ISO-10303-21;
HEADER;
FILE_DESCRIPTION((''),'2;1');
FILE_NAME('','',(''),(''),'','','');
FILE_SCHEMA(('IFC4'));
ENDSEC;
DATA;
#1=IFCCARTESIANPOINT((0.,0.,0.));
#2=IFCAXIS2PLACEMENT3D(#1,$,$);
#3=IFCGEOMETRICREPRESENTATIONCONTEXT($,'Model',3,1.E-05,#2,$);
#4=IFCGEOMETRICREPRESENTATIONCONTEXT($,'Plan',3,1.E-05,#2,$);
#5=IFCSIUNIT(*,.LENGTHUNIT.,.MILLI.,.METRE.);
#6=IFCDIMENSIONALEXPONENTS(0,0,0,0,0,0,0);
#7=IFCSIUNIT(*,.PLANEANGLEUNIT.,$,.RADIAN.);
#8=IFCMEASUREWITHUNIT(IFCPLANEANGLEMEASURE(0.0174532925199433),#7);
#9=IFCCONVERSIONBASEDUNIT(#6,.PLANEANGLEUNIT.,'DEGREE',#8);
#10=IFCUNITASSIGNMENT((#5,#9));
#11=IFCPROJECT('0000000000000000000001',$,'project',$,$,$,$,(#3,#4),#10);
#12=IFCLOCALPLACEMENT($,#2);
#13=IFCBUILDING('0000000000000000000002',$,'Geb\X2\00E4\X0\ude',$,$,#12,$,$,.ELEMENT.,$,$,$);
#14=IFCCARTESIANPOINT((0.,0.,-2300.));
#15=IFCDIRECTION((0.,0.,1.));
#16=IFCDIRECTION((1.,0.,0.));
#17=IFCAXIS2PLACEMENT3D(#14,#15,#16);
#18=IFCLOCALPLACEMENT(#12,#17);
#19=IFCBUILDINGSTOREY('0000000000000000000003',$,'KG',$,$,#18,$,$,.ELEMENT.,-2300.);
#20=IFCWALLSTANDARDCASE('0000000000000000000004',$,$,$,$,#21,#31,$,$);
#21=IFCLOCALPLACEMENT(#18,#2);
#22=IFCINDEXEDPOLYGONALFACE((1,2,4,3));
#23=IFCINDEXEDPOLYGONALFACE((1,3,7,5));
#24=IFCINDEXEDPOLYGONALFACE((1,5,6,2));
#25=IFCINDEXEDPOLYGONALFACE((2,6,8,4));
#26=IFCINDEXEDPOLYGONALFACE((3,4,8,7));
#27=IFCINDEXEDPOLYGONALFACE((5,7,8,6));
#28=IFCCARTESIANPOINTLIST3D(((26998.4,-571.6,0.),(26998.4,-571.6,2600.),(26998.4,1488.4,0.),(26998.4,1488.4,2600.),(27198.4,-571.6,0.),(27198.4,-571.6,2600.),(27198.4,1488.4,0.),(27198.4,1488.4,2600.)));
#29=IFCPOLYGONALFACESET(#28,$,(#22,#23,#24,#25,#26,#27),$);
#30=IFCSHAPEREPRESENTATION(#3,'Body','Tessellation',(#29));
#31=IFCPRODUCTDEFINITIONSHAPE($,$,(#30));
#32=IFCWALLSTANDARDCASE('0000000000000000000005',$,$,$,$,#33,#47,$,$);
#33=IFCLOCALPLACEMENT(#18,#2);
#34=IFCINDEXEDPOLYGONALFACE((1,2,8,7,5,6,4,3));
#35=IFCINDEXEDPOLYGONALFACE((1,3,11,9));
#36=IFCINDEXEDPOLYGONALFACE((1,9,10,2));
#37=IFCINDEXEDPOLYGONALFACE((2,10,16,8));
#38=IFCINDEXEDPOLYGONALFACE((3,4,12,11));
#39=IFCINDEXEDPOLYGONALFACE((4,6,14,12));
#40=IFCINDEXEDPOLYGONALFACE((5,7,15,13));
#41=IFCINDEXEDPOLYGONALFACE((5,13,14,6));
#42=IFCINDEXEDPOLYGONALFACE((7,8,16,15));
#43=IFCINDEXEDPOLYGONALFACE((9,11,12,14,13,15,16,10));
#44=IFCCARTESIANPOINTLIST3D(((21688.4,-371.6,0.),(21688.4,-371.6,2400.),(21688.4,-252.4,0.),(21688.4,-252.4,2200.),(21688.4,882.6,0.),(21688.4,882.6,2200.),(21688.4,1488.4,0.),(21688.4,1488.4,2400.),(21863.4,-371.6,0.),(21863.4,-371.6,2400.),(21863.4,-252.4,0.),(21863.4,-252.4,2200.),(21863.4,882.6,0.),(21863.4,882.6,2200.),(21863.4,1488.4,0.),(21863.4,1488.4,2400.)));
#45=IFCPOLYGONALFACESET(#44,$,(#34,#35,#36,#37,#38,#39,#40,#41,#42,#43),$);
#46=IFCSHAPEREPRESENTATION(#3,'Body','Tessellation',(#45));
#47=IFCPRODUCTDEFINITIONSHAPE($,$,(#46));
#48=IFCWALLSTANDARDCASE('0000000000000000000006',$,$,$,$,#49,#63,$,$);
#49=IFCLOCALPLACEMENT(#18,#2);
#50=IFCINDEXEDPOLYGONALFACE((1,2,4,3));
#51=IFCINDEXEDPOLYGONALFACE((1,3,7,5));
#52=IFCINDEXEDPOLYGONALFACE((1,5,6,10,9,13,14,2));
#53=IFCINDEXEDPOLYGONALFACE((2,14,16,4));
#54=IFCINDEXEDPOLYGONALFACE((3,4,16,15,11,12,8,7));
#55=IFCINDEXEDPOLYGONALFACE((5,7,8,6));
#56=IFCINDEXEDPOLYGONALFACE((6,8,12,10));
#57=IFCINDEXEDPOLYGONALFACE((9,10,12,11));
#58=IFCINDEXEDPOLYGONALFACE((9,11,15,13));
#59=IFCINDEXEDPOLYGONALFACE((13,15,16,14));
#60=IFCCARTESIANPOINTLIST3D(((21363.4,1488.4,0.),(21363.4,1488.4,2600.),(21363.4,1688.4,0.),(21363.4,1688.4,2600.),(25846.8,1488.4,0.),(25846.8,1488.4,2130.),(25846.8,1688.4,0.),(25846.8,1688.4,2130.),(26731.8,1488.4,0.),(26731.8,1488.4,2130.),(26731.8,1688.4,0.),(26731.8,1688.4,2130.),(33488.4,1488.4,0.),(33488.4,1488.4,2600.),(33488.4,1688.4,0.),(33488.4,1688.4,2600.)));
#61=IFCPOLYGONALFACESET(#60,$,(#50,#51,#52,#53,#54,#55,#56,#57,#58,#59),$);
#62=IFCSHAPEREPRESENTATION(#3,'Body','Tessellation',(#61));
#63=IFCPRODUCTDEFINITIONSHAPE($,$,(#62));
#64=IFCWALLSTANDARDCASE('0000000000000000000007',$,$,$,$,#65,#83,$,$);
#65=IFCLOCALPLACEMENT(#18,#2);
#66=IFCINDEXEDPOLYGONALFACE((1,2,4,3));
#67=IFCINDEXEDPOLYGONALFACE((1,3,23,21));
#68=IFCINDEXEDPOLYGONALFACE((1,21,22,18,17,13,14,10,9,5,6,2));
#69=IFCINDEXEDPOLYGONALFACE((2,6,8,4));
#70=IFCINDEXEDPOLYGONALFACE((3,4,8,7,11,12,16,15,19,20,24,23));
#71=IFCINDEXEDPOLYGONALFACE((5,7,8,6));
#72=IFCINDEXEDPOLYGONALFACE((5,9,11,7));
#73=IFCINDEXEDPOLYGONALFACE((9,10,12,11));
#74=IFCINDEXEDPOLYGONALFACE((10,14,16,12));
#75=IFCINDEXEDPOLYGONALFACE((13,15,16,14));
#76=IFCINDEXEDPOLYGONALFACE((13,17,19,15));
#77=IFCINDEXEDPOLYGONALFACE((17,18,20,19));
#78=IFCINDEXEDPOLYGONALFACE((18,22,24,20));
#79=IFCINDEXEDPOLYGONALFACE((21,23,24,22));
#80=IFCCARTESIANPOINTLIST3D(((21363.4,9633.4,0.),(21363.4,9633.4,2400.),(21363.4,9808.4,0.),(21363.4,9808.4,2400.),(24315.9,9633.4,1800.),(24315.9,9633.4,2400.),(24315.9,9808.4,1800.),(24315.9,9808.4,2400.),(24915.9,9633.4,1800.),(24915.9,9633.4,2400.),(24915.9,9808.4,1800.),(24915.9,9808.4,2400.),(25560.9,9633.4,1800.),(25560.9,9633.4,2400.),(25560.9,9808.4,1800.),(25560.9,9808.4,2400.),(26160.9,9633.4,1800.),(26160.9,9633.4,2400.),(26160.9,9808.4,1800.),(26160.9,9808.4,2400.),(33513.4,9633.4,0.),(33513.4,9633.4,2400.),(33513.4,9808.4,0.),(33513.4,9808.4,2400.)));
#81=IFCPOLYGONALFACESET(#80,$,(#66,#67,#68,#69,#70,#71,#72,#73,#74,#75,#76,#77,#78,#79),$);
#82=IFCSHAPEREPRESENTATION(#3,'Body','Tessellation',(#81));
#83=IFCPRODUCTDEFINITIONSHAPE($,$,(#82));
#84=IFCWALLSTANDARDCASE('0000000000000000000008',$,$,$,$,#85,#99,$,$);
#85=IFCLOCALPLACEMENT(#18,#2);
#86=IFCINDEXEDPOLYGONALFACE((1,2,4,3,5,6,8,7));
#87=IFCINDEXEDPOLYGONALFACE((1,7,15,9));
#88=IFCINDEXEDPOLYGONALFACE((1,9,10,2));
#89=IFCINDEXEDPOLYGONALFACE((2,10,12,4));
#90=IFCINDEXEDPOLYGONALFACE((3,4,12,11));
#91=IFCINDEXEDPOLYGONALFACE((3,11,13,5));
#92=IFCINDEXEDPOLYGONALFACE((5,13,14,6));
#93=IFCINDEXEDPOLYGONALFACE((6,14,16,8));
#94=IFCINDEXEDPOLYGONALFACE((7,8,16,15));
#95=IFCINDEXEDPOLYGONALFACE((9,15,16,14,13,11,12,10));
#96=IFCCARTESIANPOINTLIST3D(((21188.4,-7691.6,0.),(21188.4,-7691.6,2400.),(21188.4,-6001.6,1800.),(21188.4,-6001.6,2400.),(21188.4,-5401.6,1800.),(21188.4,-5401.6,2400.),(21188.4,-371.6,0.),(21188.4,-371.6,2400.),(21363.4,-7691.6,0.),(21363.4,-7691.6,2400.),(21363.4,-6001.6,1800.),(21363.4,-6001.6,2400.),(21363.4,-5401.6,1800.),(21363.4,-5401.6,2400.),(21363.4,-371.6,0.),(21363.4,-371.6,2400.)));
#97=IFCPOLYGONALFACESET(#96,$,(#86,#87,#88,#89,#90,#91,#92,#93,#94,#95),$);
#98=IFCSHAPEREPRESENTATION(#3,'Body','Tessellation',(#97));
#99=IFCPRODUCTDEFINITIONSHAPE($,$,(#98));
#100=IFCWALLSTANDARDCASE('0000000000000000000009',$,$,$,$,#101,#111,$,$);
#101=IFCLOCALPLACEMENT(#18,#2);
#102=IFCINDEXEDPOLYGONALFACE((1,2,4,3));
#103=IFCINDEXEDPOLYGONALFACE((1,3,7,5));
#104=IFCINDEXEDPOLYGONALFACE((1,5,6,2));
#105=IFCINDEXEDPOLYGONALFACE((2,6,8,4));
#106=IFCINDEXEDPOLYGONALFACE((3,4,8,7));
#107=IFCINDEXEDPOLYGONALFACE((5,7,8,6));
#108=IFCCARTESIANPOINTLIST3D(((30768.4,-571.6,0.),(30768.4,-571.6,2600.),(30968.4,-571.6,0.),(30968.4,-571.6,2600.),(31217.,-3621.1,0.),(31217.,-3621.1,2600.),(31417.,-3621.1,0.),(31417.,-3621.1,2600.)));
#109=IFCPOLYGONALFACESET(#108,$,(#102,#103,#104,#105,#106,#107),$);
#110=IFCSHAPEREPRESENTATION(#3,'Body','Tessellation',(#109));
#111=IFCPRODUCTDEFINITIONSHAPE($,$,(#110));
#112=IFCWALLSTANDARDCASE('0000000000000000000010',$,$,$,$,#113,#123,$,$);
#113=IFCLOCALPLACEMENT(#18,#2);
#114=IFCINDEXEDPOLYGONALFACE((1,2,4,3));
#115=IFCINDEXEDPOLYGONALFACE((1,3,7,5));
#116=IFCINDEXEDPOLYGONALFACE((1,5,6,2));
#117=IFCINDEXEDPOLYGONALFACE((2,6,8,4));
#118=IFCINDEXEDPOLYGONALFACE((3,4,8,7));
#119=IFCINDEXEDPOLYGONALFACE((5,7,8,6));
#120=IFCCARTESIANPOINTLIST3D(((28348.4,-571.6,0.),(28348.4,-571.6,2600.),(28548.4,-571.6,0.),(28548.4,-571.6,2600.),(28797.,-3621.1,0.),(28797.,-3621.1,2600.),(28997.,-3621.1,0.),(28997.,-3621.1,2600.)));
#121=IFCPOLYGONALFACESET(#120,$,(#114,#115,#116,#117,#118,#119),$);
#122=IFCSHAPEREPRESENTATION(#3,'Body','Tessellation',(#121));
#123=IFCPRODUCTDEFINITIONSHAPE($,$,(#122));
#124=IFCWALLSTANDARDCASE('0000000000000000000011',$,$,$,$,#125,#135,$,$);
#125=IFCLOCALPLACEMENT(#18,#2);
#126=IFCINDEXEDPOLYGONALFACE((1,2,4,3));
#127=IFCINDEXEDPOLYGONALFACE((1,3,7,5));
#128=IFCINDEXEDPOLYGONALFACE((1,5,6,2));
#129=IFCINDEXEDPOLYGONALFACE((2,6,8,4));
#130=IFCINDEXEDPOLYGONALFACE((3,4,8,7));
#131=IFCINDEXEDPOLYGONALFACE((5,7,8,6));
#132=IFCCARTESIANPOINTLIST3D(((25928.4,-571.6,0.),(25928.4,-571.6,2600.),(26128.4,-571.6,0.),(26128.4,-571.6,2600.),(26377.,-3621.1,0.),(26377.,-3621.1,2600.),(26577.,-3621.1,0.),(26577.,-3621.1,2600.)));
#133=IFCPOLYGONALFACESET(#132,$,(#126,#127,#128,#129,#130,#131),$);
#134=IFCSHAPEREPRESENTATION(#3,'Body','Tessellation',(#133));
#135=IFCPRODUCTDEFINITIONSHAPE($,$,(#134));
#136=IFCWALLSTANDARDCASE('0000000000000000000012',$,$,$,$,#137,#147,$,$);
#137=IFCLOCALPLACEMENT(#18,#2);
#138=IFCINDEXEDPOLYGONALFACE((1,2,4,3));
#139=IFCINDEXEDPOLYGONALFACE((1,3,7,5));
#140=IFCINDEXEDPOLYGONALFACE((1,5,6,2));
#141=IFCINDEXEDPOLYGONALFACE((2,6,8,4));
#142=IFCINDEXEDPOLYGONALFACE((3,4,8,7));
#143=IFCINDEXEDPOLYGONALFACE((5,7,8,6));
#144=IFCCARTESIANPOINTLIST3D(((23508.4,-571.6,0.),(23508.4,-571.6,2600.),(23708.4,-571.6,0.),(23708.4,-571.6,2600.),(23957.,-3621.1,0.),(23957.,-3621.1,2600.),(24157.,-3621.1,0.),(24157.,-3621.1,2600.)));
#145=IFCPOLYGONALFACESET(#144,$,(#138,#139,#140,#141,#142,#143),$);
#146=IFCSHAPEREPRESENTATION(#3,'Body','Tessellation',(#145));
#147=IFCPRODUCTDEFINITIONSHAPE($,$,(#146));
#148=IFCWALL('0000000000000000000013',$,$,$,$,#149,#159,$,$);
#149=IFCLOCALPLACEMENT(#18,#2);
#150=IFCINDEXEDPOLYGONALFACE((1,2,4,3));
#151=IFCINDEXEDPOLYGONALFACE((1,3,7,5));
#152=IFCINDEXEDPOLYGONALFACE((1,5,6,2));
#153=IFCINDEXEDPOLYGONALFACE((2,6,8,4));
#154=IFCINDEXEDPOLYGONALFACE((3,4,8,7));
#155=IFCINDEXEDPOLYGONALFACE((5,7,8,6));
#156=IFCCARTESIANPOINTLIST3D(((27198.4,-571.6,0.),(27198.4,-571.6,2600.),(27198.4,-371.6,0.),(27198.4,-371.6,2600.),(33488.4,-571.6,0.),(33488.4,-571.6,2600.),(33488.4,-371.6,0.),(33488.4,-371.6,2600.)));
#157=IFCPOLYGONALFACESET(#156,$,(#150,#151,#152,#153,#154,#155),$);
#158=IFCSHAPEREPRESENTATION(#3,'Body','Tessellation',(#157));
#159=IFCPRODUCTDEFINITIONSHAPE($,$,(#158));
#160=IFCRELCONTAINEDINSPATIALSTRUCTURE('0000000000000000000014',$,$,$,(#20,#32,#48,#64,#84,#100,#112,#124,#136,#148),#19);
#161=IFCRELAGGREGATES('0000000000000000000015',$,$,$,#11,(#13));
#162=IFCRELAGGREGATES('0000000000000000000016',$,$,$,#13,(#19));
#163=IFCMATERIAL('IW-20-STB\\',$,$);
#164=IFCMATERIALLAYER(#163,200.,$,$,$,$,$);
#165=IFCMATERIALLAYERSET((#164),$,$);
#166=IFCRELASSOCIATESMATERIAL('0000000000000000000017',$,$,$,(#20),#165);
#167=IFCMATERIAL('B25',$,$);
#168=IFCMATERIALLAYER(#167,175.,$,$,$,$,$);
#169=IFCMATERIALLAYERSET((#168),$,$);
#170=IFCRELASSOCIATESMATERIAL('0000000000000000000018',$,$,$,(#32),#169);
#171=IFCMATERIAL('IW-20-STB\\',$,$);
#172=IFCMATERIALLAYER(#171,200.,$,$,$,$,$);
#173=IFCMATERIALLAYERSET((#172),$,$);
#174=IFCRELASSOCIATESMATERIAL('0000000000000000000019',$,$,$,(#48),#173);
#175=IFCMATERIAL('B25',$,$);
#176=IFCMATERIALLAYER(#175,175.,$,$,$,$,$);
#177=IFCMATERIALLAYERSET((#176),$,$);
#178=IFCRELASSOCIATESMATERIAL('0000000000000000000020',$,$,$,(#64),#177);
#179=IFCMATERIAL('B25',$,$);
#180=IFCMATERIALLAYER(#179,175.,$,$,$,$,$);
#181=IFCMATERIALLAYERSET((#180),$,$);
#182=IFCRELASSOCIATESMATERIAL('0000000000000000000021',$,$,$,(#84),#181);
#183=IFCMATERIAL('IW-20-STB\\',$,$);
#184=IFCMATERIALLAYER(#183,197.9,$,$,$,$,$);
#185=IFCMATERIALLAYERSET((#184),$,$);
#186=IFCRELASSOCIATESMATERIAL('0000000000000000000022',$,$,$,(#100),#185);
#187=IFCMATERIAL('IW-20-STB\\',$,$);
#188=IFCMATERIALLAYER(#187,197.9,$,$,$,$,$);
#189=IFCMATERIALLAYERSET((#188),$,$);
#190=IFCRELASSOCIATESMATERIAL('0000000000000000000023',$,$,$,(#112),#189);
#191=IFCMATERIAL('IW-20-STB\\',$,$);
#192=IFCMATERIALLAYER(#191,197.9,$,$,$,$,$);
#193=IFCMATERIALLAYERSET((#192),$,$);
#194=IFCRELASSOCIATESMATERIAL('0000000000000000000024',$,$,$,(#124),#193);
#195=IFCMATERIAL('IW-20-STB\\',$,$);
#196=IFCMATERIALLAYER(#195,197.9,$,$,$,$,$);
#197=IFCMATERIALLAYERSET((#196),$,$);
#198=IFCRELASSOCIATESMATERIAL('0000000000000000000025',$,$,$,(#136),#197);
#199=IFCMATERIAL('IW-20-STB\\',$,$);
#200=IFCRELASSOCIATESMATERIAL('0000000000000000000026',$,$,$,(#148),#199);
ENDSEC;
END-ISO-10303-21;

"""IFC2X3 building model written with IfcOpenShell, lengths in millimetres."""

from ifc_helpers import new_model, entity, si_unit, converted_unit, frame, frame_2d, origin, origin_with_axes, place, context, project, spatial, polyline, rectangle, outline, extrude, material, layer, layer_set, layer_usage, element, save


model = new_model("IFC2X3")

# Units and contexts
model_context = context("Model", 3, precision=1e-05, world=origin())
plan_context = context("Plan", 3, precision=1e-05, world=origin())
ifc_project = project(units=[si_unit("LENGTHUNIT", "METRE", prefix="MILLI"), converted_unit("PLANEANGLEUNIT", "DEGREE", entity("IfcPlaneAngleMeasure", 0.0174532925199433), si_unit("PLANEANGLEUNIT", "RADIAN"), dimensions=[0, 0, 0, 0, 0, 0, 0])], contexts=[model_context, plan_context])

# Building, storey
building_placement = place(None, origin())
building = spatial("IfcBuilding", under=ifc_project, at=building_placement, Name="Gebäude", CompositionType="ELEMENT")
storey_placement = place(building_placement, frame((0.0, 0.0, -2300.0), z_axis=(0.0, 0.0, 1.0), x_axis=(1.0, 0.0, 0.0)))
storey = spatial("IfcBuildingStorey", under=building, at=storey_placement, Name="KG", CompositionType="ELEMENT", Elevation=-2300.0)

# Wall
ifc_material_1 = material(Name="IW-20-STB\\")
ifc_layer_1 = layer(ifc_material_1, 200.0)
ifc_layer_set_1 = layer_set([ifc_layer_1])
ifc_layer_usage_1 = layer_usage(ifc_layer_set_1, "AXIS2", "POSITIVE", -200.0)
wall_1_placement = place(storey_placement, frame((26998.4, 1488.4, 0.0), z_axis=(0.0, 0.0, 1.0), x_axis=(0.0, -1.0, 0.0)))
element("IfcWallStandardCase", 1, at=wall_1_placement, inside=storey, material=ifc_layer_usage_1, context=model_context, shape_type="SweptSolid", body=[
    extrude(rectangle(XDim=2060.0, YDim=200.0, at=frame_2d((1030.0, 100.0), x_axis=(1.0, 0.0))), origin_with_axes(), (0.0, 0.0, 1.0), 2600.0),
])

# Walls, openings
ifc_material_2 = material(Name="B25")
ifc_layer_2 = layer(ifc_material_2, 175.0)
ifc_layer_set_2 = layer_set([ifc_layer_2])
ifc_layer_usage_2 = layer_usage(ifc_layer_set_2, "AXIS2", "POSITIVE", 0.0)
wall_2_placement = place(storey_placement, frame((21688.4, 1488.4, 0.0), z_axis=(0.0, 0.0, 1.0), x_axis=(0.0, -1.0, 0.0)))
wall_2 = element("IfcWallStandardCase", 2, at=wall_2_placement, inside=storey, material=ifc_layer_usage_2, context=model_context, shape_type="SweptSolid", body=[
    extrude(rectangle(XDim=1860.0, YDim=175.0, at=frame_2d((930.0, 87.5), x_axis=(1.0, 0.0))), origin_with_axes(), (0.0, 0.0, 1.0), 2400.0),
])
opening_1_placement = place(wall_2_placement, frame((605.8, 0.0, 0.0), z_axis=(0.0, 1.0, 0.0), x_axis=(0.0, 0.0, 1.0)))
element("IfcOpeningElement", 3, at=opening_1_placement, cuts=wall_2, ObjectType="Opening", context=model_context, shape_type="SweptSolid", body=[
    extrude(rectangle(XDim=2200.0, YDim=1135.0, at=frame_2d((1100.0, 567.5), x_axis=(1.0, 0.0))), origin_with_axes(), (0.0, 0.0, 1.0), 175.0),
])
ifc_material_3 = material(Name="IW-20-STB\\")
ifc_layer_3 = layer(ifc_material_3, 200.0)
ifc_layer_set_3 = layer_set([ifc_layer_3])
ifc_layer_usage_3 = layer_usage(ifc_layer_set_3, "AXIS2", "POSITIVE", -200.0)
wall_3_placement = place(storey_placement, frame((21363.4, 1488.4, 0.0), z_axis=(0.0, 0.0, 1.0), x_axis=(1.0, 0.0, 0.0)))
wall_3 = element("IfcWallStandardCase", 4, at=wall_3_placement, inside=storey, material=ifc_layer_usage_3, context=model_context, shape_type="SweptSolid", body=[
    extrude(rectangle(XDim=12125.0, YDim=200.0, at=frame_2d((6062.5, 100.0), x_axis=(1.0, 0.0))), origin_with_axes(), (0.0, 0.0, 1.0), 2600.0),
])
opening_2_placement = place(wall_3_placement, frame((4483.5, 0.0, 0.0), z_axis=(0.0, 1.0, 0.0), x_axis=(0.0, 0.0, 1.0)))
element("IfcOpeningElement", 5, at=opening_2_placement, cuts=wall_3, ObjectType="Opening", context=model_context, shape_type="SweptSolid", body=[
    extrude(rectangle(XDim=2130.0, YDim=885.0, at=frame_2d((1065.0, 442.5), x_axis=(1.0, 0.0))), origin_with_axes(), (0.0, 0.0, 1.0), 200.0),
])

# Wall, openings
ifc_material_4 = material(Name="B25")
ifc_layer_4 = layer(ifc_material_4, 175.0)
ifc_layer_set_4 = layer_set([ifc_layer_4])
ifc_layer_usage_4 = layer_usage(ifc_layer_set_4, "AXIS2", "POSITIVE", 0.0)
wall_4_placement = place(storey_placement, frame((33513.4, 9808.4, 0.0), z_axis=(0.0, 0.0, 1.0), x_axis=(-1.0, 0.0, 0.0)))
wall_4 = element("IfcWallStandardCase", 6, at=wall_4_placement, inside=storey, material=ifc_layer_usage_4, context=model_context, shape_type="SweptSolid", body=[
    extrude(rectangle(XDim=12150.0, YDim=175.0, at=frame_2d((6075.0, 87.5), x_axis=(1.0, 0.0))), origin_with_axes(), (0.0, 0.0, 1.0), 2400.0),
])
opening_3_placement = place(wall_4_placement, frame((7352.5, 0.0, 1800.0), z_axis=(0.0, 1.0, 0.0), x_axis=(0.0, 0.0, 1.0)))
element("IfcOpeningElement", 7, at=opening_3_placement, cuts=wall_4, ObjectType="Opening", context=model_context, shape_type="SweptSolid", body=[
    extrude(rectangle(XDim=600.0, YDim=600.0, at=frame_2d((300.0, 300.0), x_axis=(1.0, 0.0))), origin_with_axes(), (0.0, 0.0, 1.0), 175.0),
])
opening_4_placement = place(wall_4_placement, frame((8597.5, 0.0, 1800.0), z_axis=(0.0, 1.0, 0.0), x_axis=(0.0, 0.0, 1.0)))
element("IfcOpeningElement", 8, at=opening_4_placement, cuts=wall_4, ObjectType="Opening", context=model_context, shape_type="SweptSolid", body=[
    extrude(rectangle(XDim=600.0, YDim=600.0, at=frame_2d((300.0, 300.0), x_axis=(1.0, 0.0))), origin_with_axes(), (0.0, 0.0, 1.0), 175.0),
])

# Wall, opening
ifc_material_5 = material(Name="B25")
ifc_layer_5 = layer(ifc_material_5, 175.0)
ifc_layer_set_5 = layer_set([ifc_layer_5])
ifc_layer_usage_5 = layer_usage(ifc_layer_set_5, "AXIS2", "POSITIVE", 0.0)
wall_5_placement = place(storey_placement, frame((21188.4, -371.6, 0.0), z_axis=(0.0, 0.0, 1.0), x_axis=(0.0, -1.0, 0.0)))
wall_5 = element("IfcWallStandardCase", 9, at=wall_5_placement, inside=storey, material=ifc_layer_usage_5, context=model_context, shape_type="SweptSolid", body=[
    extrude(rectangle(XDim=7320.0, YDim=175.0, at=frame_2d((3660.0, 87.5), x_axis=(1.0, 0.0))), origin_with_axes(), (0.0, 0.0, 1.0), 2400.0),
])
opening_5_placement = place(wall_5_placement, frame((5030.0, 0.0, 1800.0), z_axis=(0.0, 1.0, 0.0), x_axis=(0.0, 0.0, 1.0)))
element("IfcOpeningElement", 10, at=opening_5_placement, cuts=wall_5, ObjectType="Opening", context=model_context, shape_type="SweptSolid", body=[
    extrude(rectangle(XDim=600.0, YDim=600.0, at=frame_2d((300.0, 300.0), x_axis=(1.0, 0.0))), origin_with_axes(), (0.0, 0.0, 1.0), 175.0),
])

# Walls
ifc_material_6 = material(Name="IW-20-STB\\")
ifc_layer_6 = layer(ifc_material_6, 197.9)
ifc_layer_set_6 = layer_set([ifc_layer_6])
ifc_layer_usage_6 = layer_usage(ifc_layer_set_6, "AXIS2", "POSITIVE", -200.0)
wall_6_placement = place(storey_placement, frame((30768.4, -571.6, 0.0), z_axis=(0.0, 0.0, 1.0), x_axis=(0.145539, -0.989353, 0.0)))
element("IfcWallStandardCase", 11, at=wall_6_placement, inside=storey, material=ifc_layer_usage_6, context=model_context, shape_type="SweptSolid", body=[
    extrude(outline(polyline([(0.0, 0.0), (3082.4, 0.0), (3111.5, 197.9), (29.1, 197.9), (0.0, 0.0)])), origin_with_axes(), (0.0, 0.0, 1.0), 2600.0),
])
ifc_material_7 = material(Name="IW-20-STB\\")
ifc_layer_7 = layer(ifc_material_7, 197.9)
ifc_layer_set_7 = layer_set([ifc_layer_7])
ifc_layer_usage_7 = layer_usage(ifc_layer_set_7, "AXIS2", "POSITIVE", -200.0)
wall_7_placement = place(storey_placement, frame((28348.4, -571.6, 0.0), z_axis=(0.0, 0.0, 1.0), x_axis=(0.145539, -0.989353, 0.0)))
element("IfcWallStandardCase", 12, at=wall_7_placement, inside=storey, material=ifc_layer_usage_7, context=model_context, shape_type="SweptSolid", body=[
    extrude(outline(polyline([(0.0, 0.0), (3082.4, 0.0), (3111.5, 197.9), (29.1, 197.9), (0.0, 0.0)])), origin_with_axes(), (0.0, 0.0, 1.0), 2600.0),
])
ifc_material_8 = material(Name="IW-20-STB\\")
ifc_layer_8 = layer(ifc_material_8, 197.9)
ifc_layer_set_8 = layer_set([ifc_layer_8])
ifc_layer_usage_8 = layer_usage(ifc_layer_set_8, "AXIS2", "POSITIVE", -200.0)
wall_8_placement = place(storey_placement, frame((25928.4, -571.6, 0.0), z_axis=(0.0, 0.0, 1.0), x_axis=(0.145539, -0.989353, 0.0)))
element("IfcWallStandardCase", 13, at=wall_8_placement, inside=storey, material=ifc_layer_usage_8, context=model_context, shape_type="SweptSolid", body=[
    extrude(outline(polyline([(0.0, 0.0), (3082.4, 0.0), (3111.5, 197.9), (29.1, 197.9), (0.0, 0.0)])), origin_with_axes(), (0.0, 0.0, 1.0), 2600.0),
])
ifc_material_9 = material(Name="IW-20-STB\\")
ifc_layer_9 = layer(ifc_material_9, 197.9)
ifc_layer_set_9 = layer_set([ifc_layer_9])
ifc_layer_usage_9 = layer_usage(ifc_layer_set_9, "AXIS2", "POSITIVE", -200.0)
wall_9_placement = place(storey_placement, frame((23508.4, -571.6, 0.0), z_axis=(0.0, 0.0, 1.0), x_axis=(0.145539, -0.989353, 0.0)))
element("IfcWallStandardCase", 14, at=wall_9_placement, inside=storey, material=ifc_layer_usage_9, context=model_context, shape_type="SweptSolid", body=[
    extrude(outline(polyline([(0.0, 0.0), (3082.4, 0.0), (3111.5, 197.9), (29.1, 197.9), (0.0, 0.0)])), origin_with_axes(), (0.0, 0.0, 1.0), 2600.0),
])
ifc_material_10 = material(Name="IW-20-STB\\")
wall_10_placement = place(storey_placement, frame((33488.4, -371.6, 0.0), z_axis=(0.0, 0.0, 1.0), x_axis=(-1.0, 0.0, 0.0)))
element("IfcWall", 15, at=wall_10_placement, inside=storey, material=ifc_material_10, context=model_context, shape_type="SweptSolid", body=[
    extrude(outline(polyline([(0.0, 0.0), (6290.0, 0.0), (6290.0, 200.0), (0.0, 200.0), (0.0, 0.0)])), origin_with_axes(), (0.0, 0.0, 1.0), 2600.0),
])

save(model, "model.ifc")
